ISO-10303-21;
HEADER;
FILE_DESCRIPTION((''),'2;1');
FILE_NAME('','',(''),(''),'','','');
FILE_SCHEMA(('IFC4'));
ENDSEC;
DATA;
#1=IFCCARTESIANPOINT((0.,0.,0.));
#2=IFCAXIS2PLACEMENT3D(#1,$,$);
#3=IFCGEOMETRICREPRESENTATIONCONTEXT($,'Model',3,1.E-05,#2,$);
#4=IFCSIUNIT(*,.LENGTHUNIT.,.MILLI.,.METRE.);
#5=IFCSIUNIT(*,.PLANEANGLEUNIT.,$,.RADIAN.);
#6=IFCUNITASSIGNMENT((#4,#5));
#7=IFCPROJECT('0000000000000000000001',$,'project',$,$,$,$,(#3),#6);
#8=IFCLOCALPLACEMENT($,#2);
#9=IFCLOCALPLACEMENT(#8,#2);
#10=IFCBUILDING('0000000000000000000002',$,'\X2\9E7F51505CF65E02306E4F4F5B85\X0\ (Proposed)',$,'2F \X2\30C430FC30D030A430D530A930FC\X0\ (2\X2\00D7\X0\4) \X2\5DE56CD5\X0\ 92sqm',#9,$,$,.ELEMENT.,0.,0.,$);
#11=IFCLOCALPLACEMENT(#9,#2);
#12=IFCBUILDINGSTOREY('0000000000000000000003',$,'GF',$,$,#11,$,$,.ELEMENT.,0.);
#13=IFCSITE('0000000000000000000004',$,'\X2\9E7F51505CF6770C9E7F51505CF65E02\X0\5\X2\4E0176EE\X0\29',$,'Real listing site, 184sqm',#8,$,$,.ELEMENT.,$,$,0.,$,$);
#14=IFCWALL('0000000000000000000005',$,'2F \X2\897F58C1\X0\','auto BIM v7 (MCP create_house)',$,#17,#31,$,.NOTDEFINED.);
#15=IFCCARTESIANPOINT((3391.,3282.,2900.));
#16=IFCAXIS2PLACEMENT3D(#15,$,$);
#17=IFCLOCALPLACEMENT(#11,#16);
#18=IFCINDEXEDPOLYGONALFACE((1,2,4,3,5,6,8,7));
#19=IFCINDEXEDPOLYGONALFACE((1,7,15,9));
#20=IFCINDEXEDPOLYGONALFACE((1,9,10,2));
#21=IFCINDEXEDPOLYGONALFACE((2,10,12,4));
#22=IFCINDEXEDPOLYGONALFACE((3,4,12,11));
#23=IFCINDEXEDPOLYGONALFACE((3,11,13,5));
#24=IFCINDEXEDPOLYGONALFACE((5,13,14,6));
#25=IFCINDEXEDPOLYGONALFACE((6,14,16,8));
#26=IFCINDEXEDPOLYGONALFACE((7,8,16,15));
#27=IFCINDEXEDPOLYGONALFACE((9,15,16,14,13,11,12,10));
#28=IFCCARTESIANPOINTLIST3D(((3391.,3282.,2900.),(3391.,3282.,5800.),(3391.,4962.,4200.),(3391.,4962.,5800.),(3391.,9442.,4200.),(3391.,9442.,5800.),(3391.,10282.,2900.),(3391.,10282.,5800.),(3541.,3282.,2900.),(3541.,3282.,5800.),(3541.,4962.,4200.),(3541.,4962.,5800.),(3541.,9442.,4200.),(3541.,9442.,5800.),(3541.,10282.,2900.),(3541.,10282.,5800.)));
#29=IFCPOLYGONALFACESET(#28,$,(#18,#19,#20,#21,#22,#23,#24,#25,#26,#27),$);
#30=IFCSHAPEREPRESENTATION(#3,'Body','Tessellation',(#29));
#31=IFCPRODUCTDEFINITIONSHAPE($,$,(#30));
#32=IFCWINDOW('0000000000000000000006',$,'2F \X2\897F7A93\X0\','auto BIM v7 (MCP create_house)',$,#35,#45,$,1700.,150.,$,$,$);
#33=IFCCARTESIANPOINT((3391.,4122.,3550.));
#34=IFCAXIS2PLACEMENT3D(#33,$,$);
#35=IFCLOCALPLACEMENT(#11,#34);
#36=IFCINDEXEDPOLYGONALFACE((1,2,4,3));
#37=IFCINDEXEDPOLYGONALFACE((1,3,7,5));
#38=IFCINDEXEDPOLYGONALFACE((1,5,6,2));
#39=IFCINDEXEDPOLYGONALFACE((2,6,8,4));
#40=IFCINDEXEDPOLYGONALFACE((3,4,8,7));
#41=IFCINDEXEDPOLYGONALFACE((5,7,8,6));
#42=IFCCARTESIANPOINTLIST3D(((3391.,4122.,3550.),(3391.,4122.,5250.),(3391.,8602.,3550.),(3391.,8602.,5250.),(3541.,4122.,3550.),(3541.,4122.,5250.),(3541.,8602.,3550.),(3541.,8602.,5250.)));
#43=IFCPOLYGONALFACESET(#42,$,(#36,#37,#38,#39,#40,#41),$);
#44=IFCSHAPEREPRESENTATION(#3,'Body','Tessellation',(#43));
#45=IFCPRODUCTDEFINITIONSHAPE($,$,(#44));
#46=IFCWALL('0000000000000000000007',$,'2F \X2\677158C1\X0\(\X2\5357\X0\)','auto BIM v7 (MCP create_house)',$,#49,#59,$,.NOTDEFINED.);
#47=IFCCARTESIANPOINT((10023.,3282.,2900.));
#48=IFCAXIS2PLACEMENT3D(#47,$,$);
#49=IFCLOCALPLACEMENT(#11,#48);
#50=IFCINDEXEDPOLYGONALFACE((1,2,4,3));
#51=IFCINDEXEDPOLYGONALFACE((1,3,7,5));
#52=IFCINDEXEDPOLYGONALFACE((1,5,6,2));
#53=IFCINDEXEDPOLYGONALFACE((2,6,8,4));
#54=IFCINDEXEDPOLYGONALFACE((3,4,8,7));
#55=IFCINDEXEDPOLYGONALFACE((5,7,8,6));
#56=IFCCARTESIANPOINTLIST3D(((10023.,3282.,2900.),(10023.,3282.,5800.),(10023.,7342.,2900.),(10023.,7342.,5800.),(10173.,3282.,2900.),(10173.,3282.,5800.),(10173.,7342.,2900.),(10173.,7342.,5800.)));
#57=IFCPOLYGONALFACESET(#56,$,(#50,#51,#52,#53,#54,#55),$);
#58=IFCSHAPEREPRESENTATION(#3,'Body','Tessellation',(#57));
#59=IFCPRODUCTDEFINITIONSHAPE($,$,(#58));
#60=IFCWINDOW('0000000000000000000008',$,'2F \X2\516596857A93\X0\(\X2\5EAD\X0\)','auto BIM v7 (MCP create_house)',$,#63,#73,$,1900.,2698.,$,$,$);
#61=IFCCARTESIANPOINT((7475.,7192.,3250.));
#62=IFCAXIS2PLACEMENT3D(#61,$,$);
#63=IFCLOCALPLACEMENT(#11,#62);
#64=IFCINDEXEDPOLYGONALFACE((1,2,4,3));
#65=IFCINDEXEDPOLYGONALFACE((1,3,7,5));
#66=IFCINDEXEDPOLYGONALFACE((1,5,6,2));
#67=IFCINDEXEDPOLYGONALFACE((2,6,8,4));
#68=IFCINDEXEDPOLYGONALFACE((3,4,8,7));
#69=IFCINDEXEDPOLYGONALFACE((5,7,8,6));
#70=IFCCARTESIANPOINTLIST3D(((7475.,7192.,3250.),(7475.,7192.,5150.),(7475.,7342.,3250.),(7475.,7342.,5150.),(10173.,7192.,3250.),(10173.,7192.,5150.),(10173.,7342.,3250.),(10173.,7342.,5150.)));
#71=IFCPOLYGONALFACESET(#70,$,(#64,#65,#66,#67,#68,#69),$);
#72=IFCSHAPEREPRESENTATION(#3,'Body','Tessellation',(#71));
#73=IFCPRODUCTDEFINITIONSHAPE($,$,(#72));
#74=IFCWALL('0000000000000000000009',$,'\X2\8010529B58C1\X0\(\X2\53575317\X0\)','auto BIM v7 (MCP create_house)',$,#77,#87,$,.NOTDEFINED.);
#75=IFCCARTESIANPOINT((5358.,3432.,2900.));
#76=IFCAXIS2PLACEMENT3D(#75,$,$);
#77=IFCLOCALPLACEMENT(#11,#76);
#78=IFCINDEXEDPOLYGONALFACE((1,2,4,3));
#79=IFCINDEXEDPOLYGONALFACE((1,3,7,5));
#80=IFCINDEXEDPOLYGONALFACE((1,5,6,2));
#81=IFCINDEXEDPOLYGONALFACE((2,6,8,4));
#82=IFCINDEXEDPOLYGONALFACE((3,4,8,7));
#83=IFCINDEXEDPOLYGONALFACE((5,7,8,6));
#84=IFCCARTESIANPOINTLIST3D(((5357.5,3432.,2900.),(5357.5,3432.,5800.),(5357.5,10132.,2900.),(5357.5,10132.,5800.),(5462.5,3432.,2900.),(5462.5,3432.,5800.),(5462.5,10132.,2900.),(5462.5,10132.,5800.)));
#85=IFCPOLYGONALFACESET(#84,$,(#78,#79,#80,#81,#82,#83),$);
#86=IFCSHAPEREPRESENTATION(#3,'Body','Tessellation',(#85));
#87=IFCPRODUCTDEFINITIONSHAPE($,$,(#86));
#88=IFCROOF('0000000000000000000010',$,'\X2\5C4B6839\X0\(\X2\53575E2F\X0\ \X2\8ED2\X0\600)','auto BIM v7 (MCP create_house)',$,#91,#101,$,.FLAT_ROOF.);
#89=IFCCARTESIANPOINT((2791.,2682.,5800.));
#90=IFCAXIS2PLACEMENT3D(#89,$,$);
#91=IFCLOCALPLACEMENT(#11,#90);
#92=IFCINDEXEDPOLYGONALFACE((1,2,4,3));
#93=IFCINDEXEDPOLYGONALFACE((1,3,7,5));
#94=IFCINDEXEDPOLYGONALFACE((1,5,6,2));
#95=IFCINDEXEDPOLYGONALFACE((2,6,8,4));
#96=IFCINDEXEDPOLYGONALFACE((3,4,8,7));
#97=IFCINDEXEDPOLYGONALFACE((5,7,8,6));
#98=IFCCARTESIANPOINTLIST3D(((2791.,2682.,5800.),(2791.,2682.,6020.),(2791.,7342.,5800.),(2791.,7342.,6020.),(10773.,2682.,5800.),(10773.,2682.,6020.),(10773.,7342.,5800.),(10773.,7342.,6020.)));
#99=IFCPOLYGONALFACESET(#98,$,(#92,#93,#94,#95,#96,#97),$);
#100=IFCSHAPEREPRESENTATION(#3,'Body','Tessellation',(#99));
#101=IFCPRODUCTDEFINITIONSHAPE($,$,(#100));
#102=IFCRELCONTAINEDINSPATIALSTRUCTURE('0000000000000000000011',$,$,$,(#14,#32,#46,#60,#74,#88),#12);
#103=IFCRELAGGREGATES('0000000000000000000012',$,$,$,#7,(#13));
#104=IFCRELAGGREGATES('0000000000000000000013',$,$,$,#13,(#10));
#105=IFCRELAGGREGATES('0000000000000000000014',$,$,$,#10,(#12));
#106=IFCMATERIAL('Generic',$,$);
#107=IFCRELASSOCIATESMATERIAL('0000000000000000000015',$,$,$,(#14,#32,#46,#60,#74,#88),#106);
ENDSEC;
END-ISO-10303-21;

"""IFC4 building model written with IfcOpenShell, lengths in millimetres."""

from ifc_helpers import new_model, si_unit, frame, frame_2d, origin, place, context, project, spatial, rectangle, extrude, material, element, fill, save


model = new_model("IFC4")

# Units and contexts
model_context = context("Model", 3, precision=1e-05, world=origin())
ifc_project = project(units=[si_unit("LENGTHUNIT", "METRE", prefix="MILLI"), si_unit("PLANEANGLEUNIT", "RADIAN")], contexts=[model_context])

# Site, building, storey
site_placement = place(None, origin())
site = spatial("IfcSite", under=ifc_project, at=site_placement, Name="鹿児島県鹿児島市5丁目29", ObjectType="Real listing site, 184sqm", CompositionType="ELEMENT", RefElevation=0.0)
building_placement = place(site_placement, origin())
building = spatial("IfcBuilding", under=site, at=building_placement, Name="鹿児島市の住宅 (Proposed)", ObjectType="2F ツーバイフォー (2×4) 工法 92sqm", CompositionType="ELEMENT", ElevationOfRefHeight=0.0, ElevationOfTerrain=0.0)
storey_placement = place(building_placement, origin())
storey = spatial("IfcBuildingStorey", under=building, at=storey_placement, Name="GF", CompositionType="ELEMENT", Elevation=0.0)

# Shared definitions
ifc_material = material(Name="Generic")

# Walls, openings, windows
wall_1_placement = place(storey_placement, frame((3391.0, 3282.0, 2900.0)))
wall_1 = element("IfcWall", 1, at=wall_1_placement, inside=storey, material=ifc_material, Name="2F 西壁", Description="auto BIM v7 (MCP create_house)", PredefinedType="NOTDEFINED", context=model_context, shape_type="SweptSolid", body=[
    extrude(rectangle(XDim=150.0, YDim=7000.0, at=frame_2d((75.0, 3500.0))), frame((3391.0, 3282.0, 2900.0)), (0.0, 0.0, 1.0), 2900.0),
])
opening_1_placement = place(storey_placement, frame((3391.0, 4122.0, 3550.0)))
opening_1 = element("IfcOpeningElement", 2, at=opening_1_placement, cuts=wall_1, PredefinedType="NOTDEFINED", context=model_context, shape_type="SweptSolid", body=[
    extrude(rectangle(XDim=150.0, YDim=4480.0, at=frame_2d((75.0, 2240.0))), frame((3391.0, 4122.0, 3550.0)), (0.0, 0.0, 1.0), 1700.0),
])
window_1_placement = place(storey_placement, frame((3391.0, 4122.0, 3550.0)))
window_1 = element("IfcWindow", 3, at=window_1_placement, inside=storey, material=ifc_material, Name="2F 西窓", Description="auto BIM v7 (MCP create_house)", OverallHeight=1700.0, OverallWidth=150.0, context=model_context, shape_type="SweptSolid", body=[
    extrude(rectangle(XDim=150.0, YDim=4480.0, at=frame_2d((75.0, 2240.0))), frame((3391.0, 4122.0, 3550.0)), (0.0, 0.0, 1.0), 1700.0),
])
fill(opening_1, window_1)
wall_2_placement = place(storey_placement, frame((10023.0, 3282.0, 2900.0)))
wall_2 = element("IfcWall", 4, at=wall_2_placement, inside=storey, material=ifc_material, Name="2F 東壁(南)", Description="auto BIM v7 (MCP create_house)", PredefinedType="NOTDEFINED", context=model_context, shape_type="SweptSolid", body=[
    extrude(rectangle(XDim=150.0, YDim=4060.0, at=frame_2d((75.0, 2030.0))), frame((10023.0, 3282.0, 2900.0)), (0.0, 0.0, 1.0), 2900.0),
])
opening_2_placement = place(storey_placement, frame((7475.0, 7192.0, 3250.0)))
opening_2 = element("IfcOpeningElement", 5, at=opening_2_placement, cuts=wall_2, PredefinedType="NOTDEFINED", context=model_context, shape_type="SweptSolid", body=[
    extrude(rectangle(XDim=2698.0, YDim=150.0, at=frame_2d((1349.0, 75.0))), frame((7475.0, 7192.0, 3250.0)), (0.0, 0.0, 1.0), 1900.0),
])
window_2_placement = place(storey_placement, frame((7475.0, 7192.0, 3250.0)))
window_2 = element("IfcWindow", 6, at=window_2_placement, inside=storey, material=ifc_material, Name="2F 入隅窓(庭)", Description="auto BIM v7 (MCP create_house)", OverallHeight=1900.0, OverallWidth=2698.0, context=model_context, shape_type="SweptSolid", body=[
    extrude(rectangle(XDim=2698.0, YDim=150.0, at=frame_2d((1349.0, 75.0))), frame((7475.0, 7192.0, 3250.0)), (0.0, 0.0, 1.0), 1900.0),
])
fill(opening_2, window_2)

# Wall
wall_3_placement = place(storey_placement, frame((5358.0, 3432.0, 2900.0)))
element("IfcWall", 7, at=wall_3_placement, inside=storey, material=ifc_material, Name="耐力壁(南北)", Description="auto BIM v7 (MCP create_house)", PredefinedType="NOTDEFINED", context=model_context, shape_type="SweptSolid", body=[
    extrude(rectangle(XDim=105.0, YDim=6700.0, at=frame_2d((52.0, 3350.0))), frame((5358.0, 3432.0, 2900.0)), (0.0, 0.0, 1.0), 2900.0),
])

# Roof
for number, where, name in (
    (8, (2791.0, 2682.0, 5800.0), "屋根(南帯 軒600)"),
):
    element("IfcRoof", number, at=place(storey_placement, frame(where)), inside=storey, material=ifc_material, Name=name, Description="auto BIM v7 (MCP create_house)", PredefinedType="FLAT_ROOF", context=model_context, shape_type="SweptSolid", body=[
        extrude(rectangle(XDim=7982.0, YDim=4660.0, at=frame_2d((3991.0, 2330.0))), frame((2791.0, 2682.0, 5800.0)), (0.0, 0.0, 1.0), 220.0),
    ])

save(model, "model.ifc")
